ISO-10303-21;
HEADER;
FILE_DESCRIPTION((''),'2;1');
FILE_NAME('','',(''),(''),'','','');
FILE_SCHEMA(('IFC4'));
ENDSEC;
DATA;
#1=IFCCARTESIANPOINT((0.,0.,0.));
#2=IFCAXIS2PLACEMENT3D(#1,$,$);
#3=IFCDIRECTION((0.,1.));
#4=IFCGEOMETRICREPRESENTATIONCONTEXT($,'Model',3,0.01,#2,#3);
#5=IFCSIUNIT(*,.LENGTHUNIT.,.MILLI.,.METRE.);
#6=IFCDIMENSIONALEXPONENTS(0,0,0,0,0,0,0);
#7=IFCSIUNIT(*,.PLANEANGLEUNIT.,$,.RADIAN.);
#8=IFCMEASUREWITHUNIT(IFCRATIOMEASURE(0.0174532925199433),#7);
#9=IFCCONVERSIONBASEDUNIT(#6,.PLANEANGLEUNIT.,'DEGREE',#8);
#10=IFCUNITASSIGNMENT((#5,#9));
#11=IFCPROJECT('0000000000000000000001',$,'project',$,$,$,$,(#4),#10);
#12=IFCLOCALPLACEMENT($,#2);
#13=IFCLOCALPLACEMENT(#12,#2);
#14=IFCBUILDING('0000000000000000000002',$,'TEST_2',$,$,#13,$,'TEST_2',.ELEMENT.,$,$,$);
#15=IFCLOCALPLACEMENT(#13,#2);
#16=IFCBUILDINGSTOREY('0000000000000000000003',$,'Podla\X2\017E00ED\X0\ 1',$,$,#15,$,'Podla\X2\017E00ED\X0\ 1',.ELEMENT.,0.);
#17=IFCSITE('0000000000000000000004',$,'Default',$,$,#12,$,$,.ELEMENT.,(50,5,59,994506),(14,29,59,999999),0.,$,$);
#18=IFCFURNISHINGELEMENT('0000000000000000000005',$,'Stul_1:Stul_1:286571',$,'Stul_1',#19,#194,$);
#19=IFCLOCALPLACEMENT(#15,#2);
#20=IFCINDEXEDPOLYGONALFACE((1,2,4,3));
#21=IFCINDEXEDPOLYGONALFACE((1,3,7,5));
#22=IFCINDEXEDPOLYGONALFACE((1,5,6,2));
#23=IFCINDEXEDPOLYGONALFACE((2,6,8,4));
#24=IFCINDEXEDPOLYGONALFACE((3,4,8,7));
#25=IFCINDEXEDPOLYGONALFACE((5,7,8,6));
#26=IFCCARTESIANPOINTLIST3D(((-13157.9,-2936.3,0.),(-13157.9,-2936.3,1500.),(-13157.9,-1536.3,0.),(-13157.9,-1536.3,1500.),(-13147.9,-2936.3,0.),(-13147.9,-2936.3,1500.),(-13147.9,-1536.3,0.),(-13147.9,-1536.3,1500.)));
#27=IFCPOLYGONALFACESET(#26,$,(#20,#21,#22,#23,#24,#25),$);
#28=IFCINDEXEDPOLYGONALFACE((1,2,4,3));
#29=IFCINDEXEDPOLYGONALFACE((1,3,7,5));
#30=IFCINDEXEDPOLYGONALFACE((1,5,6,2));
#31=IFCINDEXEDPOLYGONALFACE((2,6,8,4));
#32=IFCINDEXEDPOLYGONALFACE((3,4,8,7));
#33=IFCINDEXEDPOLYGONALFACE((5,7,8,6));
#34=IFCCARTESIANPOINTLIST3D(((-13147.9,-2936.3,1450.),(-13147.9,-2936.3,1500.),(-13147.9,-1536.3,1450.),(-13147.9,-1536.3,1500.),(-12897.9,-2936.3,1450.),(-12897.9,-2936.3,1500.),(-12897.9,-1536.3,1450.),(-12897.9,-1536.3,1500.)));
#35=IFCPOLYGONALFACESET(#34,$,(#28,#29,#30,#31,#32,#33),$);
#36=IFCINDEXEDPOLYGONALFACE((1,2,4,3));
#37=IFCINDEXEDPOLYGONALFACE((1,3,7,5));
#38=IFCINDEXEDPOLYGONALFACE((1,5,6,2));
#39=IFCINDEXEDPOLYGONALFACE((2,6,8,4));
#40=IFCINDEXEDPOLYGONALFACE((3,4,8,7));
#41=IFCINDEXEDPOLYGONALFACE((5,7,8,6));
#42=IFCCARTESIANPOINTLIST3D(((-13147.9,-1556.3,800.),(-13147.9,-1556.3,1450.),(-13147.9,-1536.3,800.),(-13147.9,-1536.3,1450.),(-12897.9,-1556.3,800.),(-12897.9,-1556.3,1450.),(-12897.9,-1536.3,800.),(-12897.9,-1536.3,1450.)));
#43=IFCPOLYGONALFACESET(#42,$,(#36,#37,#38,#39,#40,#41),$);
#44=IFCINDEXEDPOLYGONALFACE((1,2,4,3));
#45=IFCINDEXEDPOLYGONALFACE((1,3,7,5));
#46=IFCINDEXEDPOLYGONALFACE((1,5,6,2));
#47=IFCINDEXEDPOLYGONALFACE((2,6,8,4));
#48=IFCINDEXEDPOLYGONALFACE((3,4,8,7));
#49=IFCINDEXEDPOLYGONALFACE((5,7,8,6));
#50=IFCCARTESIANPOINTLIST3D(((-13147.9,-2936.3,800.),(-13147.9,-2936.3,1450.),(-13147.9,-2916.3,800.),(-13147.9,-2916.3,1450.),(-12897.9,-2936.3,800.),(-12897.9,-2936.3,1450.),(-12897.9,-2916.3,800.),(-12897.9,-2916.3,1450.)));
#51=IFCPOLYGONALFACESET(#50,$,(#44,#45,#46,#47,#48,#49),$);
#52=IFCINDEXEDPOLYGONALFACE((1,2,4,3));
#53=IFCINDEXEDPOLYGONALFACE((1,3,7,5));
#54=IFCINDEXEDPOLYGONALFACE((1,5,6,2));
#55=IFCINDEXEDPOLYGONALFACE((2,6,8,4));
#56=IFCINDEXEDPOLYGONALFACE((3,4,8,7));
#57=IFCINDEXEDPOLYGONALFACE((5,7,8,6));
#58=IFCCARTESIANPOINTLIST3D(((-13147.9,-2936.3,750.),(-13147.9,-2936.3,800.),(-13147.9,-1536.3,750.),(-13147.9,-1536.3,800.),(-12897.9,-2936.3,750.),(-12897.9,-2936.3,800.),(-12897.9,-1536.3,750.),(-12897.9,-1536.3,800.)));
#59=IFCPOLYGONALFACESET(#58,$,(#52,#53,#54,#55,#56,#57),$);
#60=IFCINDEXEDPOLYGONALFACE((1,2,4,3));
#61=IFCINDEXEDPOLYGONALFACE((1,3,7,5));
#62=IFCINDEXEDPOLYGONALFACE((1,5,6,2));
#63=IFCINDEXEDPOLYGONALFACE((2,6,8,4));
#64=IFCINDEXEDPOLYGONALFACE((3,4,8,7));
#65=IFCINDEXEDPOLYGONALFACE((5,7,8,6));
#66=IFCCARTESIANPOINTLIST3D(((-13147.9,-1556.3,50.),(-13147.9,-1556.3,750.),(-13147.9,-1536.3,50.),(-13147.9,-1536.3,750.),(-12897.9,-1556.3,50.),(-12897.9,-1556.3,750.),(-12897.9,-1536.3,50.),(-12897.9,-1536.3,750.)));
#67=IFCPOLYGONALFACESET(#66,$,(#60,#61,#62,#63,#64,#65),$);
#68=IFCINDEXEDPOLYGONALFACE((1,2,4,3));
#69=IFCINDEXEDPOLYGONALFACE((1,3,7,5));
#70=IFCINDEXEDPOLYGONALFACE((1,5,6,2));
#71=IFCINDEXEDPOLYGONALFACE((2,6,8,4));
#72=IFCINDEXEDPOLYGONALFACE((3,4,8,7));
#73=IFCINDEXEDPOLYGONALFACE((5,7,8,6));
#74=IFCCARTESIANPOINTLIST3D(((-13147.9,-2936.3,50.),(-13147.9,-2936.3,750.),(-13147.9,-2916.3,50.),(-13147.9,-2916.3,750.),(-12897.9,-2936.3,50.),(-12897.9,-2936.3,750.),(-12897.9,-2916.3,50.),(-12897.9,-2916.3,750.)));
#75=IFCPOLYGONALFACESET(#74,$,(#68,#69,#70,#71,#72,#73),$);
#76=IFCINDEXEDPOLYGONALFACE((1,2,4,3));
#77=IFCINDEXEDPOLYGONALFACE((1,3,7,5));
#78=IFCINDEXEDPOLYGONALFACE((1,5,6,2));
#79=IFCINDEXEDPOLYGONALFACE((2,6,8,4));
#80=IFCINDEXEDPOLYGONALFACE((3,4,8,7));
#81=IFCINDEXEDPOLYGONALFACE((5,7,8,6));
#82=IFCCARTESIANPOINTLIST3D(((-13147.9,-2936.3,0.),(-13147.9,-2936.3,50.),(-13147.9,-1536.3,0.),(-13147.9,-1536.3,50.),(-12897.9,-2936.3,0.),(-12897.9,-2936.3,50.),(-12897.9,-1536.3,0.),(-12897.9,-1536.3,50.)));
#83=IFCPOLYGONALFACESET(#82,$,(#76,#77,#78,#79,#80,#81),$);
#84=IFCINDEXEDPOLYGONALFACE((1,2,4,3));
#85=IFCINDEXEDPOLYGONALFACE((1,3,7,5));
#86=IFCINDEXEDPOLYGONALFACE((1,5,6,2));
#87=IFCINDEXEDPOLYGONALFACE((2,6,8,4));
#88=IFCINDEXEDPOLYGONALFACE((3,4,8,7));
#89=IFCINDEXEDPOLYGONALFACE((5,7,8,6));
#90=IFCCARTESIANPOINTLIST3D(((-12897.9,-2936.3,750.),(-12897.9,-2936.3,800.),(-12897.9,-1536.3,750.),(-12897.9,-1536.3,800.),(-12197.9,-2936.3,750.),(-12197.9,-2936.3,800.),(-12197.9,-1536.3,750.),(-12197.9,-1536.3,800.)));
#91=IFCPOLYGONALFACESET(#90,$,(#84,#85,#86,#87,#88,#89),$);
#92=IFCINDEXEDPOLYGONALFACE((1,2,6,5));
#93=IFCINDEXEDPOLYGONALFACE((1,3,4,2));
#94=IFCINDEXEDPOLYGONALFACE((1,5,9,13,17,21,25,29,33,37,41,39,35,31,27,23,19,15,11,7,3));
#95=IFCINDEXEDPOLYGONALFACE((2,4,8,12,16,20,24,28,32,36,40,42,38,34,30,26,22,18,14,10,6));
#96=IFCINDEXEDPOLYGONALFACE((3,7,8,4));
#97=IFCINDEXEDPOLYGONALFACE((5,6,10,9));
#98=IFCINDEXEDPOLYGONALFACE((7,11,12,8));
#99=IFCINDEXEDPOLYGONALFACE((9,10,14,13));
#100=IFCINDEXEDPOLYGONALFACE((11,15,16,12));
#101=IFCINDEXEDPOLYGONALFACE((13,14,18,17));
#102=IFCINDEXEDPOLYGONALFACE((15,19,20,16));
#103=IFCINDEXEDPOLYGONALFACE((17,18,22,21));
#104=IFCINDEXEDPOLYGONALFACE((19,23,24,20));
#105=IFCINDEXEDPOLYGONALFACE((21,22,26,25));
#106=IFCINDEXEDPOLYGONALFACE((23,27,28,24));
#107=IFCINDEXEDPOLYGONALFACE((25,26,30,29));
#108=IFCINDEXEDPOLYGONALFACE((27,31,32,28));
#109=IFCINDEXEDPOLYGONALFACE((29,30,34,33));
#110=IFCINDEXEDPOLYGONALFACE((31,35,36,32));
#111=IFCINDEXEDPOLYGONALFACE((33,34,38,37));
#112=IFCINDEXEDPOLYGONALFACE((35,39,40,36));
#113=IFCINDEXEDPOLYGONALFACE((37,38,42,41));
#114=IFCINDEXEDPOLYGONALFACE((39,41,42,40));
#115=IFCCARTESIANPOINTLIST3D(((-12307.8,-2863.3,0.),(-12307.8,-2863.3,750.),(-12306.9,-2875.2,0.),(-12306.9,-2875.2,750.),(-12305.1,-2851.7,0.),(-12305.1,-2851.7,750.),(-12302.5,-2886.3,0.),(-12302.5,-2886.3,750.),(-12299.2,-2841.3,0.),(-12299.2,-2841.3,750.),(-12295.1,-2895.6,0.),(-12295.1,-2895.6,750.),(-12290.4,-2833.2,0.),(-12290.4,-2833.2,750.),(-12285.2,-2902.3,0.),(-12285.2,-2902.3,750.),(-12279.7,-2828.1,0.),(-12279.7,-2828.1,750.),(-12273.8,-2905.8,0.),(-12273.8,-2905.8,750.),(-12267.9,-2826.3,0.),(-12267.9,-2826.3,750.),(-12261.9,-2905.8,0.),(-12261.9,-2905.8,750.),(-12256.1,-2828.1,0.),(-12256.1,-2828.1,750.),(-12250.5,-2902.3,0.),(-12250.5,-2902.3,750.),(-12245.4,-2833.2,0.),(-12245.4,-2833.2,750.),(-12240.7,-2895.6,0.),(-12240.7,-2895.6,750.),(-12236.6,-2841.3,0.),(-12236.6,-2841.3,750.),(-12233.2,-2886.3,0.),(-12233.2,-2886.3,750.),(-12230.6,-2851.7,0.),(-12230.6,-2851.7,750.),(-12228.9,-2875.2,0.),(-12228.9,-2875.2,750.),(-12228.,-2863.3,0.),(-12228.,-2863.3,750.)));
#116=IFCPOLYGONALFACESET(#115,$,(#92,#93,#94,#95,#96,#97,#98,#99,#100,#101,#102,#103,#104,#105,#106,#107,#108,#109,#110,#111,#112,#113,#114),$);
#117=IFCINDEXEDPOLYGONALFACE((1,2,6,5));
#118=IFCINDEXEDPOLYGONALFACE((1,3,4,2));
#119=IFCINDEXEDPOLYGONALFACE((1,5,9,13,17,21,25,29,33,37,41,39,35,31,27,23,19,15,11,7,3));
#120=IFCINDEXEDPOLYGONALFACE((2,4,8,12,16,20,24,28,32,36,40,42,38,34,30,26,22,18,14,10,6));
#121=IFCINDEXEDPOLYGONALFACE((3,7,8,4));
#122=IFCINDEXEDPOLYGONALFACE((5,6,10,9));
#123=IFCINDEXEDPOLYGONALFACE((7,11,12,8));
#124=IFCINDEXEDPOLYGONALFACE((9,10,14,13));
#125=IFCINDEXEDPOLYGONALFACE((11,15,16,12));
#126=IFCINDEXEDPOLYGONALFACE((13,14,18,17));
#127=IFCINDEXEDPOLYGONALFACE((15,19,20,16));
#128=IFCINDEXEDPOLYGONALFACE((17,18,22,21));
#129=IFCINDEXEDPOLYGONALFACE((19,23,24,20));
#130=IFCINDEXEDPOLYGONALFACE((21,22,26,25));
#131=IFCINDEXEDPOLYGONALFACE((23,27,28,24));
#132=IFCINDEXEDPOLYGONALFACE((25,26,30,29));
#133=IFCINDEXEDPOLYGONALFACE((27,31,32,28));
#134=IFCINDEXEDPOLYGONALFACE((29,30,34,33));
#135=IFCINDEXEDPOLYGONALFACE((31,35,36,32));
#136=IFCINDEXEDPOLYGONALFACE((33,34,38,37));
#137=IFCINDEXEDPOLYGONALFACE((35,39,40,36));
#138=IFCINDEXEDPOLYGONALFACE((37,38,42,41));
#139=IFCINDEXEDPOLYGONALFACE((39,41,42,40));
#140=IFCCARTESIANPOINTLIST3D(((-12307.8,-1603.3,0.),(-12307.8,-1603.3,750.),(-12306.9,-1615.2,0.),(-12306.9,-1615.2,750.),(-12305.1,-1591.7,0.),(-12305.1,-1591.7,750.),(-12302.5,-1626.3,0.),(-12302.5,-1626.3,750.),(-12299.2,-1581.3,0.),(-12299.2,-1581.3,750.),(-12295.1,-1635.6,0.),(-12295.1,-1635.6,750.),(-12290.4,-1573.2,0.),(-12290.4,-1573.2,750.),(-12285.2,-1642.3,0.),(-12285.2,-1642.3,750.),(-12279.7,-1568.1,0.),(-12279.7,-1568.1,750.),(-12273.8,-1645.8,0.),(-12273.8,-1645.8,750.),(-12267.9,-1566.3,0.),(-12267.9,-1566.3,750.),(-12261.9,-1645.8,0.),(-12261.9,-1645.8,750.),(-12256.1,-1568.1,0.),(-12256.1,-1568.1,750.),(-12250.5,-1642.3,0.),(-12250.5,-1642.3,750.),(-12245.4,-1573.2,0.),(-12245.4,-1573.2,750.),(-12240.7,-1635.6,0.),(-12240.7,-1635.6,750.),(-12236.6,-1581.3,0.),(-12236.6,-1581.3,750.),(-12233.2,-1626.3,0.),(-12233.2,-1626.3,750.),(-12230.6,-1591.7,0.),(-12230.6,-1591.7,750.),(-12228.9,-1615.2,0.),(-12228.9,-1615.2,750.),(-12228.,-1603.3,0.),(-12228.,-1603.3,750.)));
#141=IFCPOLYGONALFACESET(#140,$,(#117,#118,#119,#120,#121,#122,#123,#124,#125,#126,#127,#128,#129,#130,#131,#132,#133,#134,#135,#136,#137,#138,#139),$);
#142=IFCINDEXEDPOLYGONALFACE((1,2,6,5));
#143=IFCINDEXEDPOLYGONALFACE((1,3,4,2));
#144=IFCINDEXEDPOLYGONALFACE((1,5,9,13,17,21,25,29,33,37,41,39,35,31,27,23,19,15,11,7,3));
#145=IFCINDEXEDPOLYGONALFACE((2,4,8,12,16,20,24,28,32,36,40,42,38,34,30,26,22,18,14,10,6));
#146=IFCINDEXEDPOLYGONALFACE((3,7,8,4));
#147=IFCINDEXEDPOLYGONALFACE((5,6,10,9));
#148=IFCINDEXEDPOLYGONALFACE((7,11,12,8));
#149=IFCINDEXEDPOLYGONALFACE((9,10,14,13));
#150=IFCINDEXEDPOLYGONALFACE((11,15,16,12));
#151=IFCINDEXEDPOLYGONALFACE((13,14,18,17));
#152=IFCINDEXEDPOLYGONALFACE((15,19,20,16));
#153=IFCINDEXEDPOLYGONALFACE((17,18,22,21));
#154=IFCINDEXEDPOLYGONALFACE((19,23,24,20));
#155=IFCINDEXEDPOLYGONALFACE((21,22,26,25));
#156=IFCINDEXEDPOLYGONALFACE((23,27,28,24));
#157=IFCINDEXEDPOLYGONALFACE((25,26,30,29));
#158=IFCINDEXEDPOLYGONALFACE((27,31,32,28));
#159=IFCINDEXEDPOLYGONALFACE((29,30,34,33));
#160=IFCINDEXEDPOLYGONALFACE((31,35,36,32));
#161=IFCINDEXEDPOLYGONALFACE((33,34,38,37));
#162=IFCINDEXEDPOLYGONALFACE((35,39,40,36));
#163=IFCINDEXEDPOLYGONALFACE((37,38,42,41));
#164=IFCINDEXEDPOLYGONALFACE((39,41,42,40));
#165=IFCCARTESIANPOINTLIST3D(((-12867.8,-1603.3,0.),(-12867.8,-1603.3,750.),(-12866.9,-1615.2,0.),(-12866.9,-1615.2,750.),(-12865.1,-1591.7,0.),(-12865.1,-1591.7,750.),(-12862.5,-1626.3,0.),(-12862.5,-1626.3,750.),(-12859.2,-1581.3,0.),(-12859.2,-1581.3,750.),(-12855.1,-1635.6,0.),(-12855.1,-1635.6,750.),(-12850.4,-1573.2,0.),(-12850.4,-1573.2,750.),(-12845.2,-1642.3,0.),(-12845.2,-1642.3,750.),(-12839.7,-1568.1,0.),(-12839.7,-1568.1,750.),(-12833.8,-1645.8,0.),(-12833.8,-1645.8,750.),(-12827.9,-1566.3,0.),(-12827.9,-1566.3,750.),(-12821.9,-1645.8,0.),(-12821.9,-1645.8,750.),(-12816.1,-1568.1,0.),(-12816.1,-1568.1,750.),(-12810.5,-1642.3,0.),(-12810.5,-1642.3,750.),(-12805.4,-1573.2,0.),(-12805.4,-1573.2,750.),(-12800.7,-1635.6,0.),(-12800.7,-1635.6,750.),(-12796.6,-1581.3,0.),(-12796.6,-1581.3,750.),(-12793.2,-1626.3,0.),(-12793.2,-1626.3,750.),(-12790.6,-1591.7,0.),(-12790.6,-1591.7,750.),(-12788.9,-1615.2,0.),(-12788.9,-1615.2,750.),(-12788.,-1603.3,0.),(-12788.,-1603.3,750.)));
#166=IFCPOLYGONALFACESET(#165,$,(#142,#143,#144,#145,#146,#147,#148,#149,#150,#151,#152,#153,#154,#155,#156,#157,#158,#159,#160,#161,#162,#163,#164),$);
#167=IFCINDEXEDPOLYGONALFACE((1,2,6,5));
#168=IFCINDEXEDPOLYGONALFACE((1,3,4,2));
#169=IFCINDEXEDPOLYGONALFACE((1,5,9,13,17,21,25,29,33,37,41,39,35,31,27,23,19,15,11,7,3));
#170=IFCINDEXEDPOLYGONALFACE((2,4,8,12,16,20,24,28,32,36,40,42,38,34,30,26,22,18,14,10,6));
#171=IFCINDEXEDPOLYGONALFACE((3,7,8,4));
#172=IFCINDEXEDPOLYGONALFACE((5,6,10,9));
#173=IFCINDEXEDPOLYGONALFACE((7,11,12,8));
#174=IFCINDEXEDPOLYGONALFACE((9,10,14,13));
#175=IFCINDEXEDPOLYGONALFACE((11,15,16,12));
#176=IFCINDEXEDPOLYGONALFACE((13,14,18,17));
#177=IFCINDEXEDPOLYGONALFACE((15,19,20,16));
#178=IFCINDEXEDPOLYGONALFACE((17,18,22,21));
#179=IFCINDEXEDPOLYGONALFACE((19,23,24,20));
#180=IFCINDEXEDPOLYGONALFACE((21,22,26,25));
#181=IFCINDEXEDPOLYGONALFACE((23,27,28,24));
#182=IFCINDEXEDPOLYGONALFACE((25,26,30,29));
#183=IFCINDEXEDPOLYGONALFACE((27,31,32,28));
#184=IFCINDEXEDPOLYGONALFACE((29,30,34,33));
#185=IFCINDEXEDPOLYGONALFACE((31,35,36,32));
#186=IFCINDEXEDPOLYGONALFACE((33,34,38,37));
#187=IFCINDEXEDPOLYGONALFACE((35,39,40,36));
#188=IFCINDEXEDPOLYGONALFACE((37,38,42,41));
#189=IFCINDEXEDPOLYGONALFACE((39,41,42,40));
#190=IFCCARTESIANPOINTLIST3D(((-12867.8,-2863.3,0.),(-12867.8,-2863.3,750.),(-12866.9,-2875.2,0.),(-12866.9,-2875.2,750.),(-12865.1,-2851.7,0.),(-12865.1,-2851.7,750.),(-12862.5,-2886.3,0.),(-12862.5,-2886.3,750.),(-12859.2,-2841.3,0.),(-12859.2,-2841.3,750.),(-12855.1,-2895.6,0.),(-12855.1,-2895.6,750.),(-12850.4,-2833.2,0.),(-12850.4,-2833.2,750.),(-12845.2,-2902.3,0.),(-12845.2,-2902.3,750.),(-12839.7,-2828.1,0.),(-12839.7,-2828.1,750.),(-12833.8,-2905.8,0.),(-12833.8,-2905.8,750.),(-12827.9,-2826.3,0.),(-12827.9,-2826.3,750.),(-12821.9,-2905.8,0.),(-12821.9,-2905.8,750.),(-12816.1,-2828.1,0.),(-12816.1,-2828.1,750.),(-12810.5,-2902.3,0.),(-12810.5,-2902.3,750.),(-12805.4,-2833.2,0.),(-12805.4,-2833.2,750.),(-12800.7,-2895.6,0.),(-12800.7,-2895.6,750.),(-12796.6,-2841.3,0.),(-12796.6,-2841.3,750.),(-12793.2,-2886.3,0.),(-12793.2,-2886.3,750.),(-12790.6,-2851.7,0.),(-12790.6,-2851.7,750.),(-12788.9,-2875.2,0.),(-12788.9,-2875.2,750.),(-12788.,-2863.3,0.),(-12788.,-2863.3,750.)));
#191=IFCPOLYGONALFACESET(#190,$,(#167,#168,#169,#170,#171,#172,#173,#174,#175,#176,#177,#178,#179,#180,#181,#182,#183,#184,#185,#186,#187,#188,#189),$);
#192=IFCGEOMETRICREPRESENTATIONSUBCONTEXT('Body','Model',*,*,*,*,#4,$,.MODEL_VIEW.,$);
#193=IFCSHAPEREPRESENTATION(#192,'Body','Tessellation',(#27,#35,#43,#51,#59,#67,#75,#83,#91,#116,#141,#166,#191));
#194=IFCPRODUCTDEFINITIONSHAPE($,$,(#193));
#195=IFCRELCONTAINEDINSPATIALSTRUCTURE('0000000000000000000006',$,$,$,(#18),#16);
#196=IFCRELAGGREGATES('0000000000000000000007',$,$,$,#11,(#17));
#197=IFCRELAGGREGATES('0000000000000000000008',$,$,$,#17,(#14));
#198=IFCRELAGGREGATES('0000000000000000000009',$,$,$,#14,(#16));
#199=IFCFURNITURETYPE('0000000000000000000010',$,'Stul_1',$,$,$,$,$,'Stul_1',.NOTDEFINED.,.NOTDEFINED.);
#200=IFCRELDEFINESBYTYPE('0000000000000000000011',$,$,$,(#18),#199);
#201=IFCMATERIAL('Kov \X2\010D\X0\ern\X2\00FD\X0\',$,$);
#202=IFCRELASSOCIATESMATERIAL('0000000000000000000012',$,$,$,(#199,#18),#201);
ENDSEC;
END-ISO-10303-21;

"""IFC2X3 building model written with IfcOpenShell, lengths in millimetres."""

from ifc_helpers import new_model, entity, si_unit, converted_unit, direction, frame, frame_2d, origin, origin_2d_with_axis, place, context, subcontext, project, spatial, rectangle, circle, extrude, source, transform, mapped, material, type_object, type_shapes, element, save


model = new_model("IFC2X3")

# Units and contexts
model_context = context("Model", 3, precision=0.01, world=origin(), true_north=direction((0.0, 1.0)))
body_context = subcontext(model_context, "Body", "Model", "MODEL_VIEW")
ifc_project = project(units=[si_unit("LENGTHUNIT", "METRE", prefix="MILLI"), converted_unit("PLANEANGLEUNIT", "DEGREE", entity("IfcRatioMeasure", 0.0174532925199433), si_unit("PLANEANGLEUNIT", "RADIAN"), dimensions=[0, 0, 0, 0, 0, 0, 0])], contexts=[model_context])

# Site, building, storey
site_placement = place(None, origin())
site = spatial("IfcSite", under=ifc_project, at=site_placement, Name="Default", CompositionType="ELEMENT", RefLatitude=(50, 5, 59, 994506), RefLongitude=(14, 29, 59, 999999), RefElevation=0.0)
building_placement = place(site_placement, origin())
building = spatial("IfcBuilding", under=site, at=building_placement, Name="TEST_2", LongName="TEST_2", CompositionType="ELEMENT")
storey_placement = place(building_placement, origin())
storey = spatial("IfcBuildingStorey", under=building, at=storey_placement, Name="Podlaží 1", LongName="Podlaží 1", CompositionType="ELEMENT", Elevation=0.0)

# Furnishing element
ifc_material_1 = material(Name="Kov černý")
furniture_type = type_object("IfcFurnitureType", Name="Stul_1", ElementType="Stul_1", material=ifc_material_1)
shared_shape_1 = source(origin(), body_context, "Body", "SweptSolid", [
    extrude(rectangle(XDim=1400.0, YDim=10.0, at=origin_2d_with_axis()), frame((0.0, 605.0, 0.0), z_axis=(0.0, 0.0, 1.0), x_axis=(-1.0, 0.0, 0.0)), (0.0, 0.0, 1.0), 1500.0),
    extrude(rectangle(XDim=1400.0, YDim=250.0, at=frame_2d((0.0, 0.0), x_axis=(1.0, 0.0))), frame((0.0, 475.0, 1450.0), z_axis=(0.0, 0.0, 1.0), x_axis=(-1.0, 0.0, 0.0)), (0.0, 0.0, 1.0), 50.0),
    extrude(rectangle(XDim=20.0, YDim=250.0, at=origin_2d_with_axis()), frame((690.0, 475.0, 800.0), z_axis=(0.0, 0.0, 1.0), x_axis=(-1.0, 0.0, 0.0)), (0.0, 0.0, 1.0), 650.0),
    extrude(rectangle(XDim=20.0, YDim=250.0, at=frame_2d((0.0, 0.0), x_axis=(1.0, 0.0))), frame((-690.0, 475.0, 800.0), z_axis=(0.0, 0.0, 1.0), x_axis=(-1.0, 0.0, 0.0)), (0.0, 0.0, 1.0), 650.0),
    extrude(rectangle(XDim=1400.0, YDim=250.0, at=origin_2d_with_axis()), frame((0.0, 475.0, 750.0), z_axis=(0.0, 0.0, 1.0), x_axis=(-1.0, 0.0, 0.0)), (0.0, 0.0, 1.0), 50.0),
    extrude(rectangle(XDim=20.0, YDim=250.0, at=origin_2d_with_axis()), frame((690.0, 475.0, 50.0), z_axis=(0.0, 0.0, 1.0), x_axis=(-1.0, 0.0, 0.0)), (0.0, 0.0, 1.0), 700.0),
    extrude(rectangle(XDim=20.0, YDim=250.0, at=frame_2d((0.0, 0.0), x_axis=(1.0, 0.0))), frame((-690.0, 475.0, 50.0), z_axis=(0.0, 0.0, 1.0), x_axis=(-1.0, 0.0, 0.0)), (0.0, 0.0, 1.0), 700.0),
    extrude(rectangle(XDim=1400.0, YDim=250.0, at=origin_2d_with_axis()), frame((0.0, 475.0, 0.0), z_axis=(0.0, 0.0, 1.0), x_axis=(-1.0, 0.0, 0.0)), (0.0, 0.0, 1.0), 50.0),
    extrude(rectangle(XDim=1400.0, YDim=700.0, at=origin_2d_with_axis()), frame((0.0, 0.0, 750.0), z_axis=(0.0, 0.0, 1.0), x_axis=(-1.0, 0.0, 0.0)), (0.0, 0.0, 1.0), 50.0),
    extrude(circle(Radius=40.0, at=frame_2d((0.0, 0.0), x_axis=(1.0, 0.0))), frame((-630.0, -280.0, 0.0)), (0.0, 0.0, 1.0), 750.0),
    extrude(circle(Radius=40.0, at=frame_2d((0.0, 0.0), x_axis=(1.0, 0.0))), frame((630.0, -280.0, 0.0)), (0.0, 0.0, 1.0), 750.0),
    extrude(circle(Radius=40.0, at=frame_2d((0.0, 0.0), x_axis=(1.0, 0.0))), frame((630.0, 280.0, 0.0)), (0.0, 0.0, 1.0), 750.0),
    extrude(circle(Radius=40.0, at=frame_2d((0.0, 0.0), x_axis=(1.0, 0.0))), frame((-630.0, 280.0, 0.0)), (0.0, 0.0, 1.0), 750.0),
])
type_shapes(furniture_type, [shared_shape_1])
for number, where, z_axis, x_axis, name in (
    (1, (-12547.9, -2236.3, 0.0), (0.0, 0.0, 1.0), (0.0, 1.0, 0.0), "Stul_1:Stul_1:286571"),
):
    element("IfcFurnishingElement", number, at=place(storey_placement, frame(where, z_axis=z_axis, x_axis=x_axis)), inside=storey, type_object=furniture_type, material=ifc_material_1, Name=name, ObjectType="Stul_1", context=body_context, shape_type="MappedRepresentation", body=[
        mapped(shared_shape_1, transform((0.0, 0.0, 0.0), scale=1.0)),
    ])

save(model, "model.ifc")
